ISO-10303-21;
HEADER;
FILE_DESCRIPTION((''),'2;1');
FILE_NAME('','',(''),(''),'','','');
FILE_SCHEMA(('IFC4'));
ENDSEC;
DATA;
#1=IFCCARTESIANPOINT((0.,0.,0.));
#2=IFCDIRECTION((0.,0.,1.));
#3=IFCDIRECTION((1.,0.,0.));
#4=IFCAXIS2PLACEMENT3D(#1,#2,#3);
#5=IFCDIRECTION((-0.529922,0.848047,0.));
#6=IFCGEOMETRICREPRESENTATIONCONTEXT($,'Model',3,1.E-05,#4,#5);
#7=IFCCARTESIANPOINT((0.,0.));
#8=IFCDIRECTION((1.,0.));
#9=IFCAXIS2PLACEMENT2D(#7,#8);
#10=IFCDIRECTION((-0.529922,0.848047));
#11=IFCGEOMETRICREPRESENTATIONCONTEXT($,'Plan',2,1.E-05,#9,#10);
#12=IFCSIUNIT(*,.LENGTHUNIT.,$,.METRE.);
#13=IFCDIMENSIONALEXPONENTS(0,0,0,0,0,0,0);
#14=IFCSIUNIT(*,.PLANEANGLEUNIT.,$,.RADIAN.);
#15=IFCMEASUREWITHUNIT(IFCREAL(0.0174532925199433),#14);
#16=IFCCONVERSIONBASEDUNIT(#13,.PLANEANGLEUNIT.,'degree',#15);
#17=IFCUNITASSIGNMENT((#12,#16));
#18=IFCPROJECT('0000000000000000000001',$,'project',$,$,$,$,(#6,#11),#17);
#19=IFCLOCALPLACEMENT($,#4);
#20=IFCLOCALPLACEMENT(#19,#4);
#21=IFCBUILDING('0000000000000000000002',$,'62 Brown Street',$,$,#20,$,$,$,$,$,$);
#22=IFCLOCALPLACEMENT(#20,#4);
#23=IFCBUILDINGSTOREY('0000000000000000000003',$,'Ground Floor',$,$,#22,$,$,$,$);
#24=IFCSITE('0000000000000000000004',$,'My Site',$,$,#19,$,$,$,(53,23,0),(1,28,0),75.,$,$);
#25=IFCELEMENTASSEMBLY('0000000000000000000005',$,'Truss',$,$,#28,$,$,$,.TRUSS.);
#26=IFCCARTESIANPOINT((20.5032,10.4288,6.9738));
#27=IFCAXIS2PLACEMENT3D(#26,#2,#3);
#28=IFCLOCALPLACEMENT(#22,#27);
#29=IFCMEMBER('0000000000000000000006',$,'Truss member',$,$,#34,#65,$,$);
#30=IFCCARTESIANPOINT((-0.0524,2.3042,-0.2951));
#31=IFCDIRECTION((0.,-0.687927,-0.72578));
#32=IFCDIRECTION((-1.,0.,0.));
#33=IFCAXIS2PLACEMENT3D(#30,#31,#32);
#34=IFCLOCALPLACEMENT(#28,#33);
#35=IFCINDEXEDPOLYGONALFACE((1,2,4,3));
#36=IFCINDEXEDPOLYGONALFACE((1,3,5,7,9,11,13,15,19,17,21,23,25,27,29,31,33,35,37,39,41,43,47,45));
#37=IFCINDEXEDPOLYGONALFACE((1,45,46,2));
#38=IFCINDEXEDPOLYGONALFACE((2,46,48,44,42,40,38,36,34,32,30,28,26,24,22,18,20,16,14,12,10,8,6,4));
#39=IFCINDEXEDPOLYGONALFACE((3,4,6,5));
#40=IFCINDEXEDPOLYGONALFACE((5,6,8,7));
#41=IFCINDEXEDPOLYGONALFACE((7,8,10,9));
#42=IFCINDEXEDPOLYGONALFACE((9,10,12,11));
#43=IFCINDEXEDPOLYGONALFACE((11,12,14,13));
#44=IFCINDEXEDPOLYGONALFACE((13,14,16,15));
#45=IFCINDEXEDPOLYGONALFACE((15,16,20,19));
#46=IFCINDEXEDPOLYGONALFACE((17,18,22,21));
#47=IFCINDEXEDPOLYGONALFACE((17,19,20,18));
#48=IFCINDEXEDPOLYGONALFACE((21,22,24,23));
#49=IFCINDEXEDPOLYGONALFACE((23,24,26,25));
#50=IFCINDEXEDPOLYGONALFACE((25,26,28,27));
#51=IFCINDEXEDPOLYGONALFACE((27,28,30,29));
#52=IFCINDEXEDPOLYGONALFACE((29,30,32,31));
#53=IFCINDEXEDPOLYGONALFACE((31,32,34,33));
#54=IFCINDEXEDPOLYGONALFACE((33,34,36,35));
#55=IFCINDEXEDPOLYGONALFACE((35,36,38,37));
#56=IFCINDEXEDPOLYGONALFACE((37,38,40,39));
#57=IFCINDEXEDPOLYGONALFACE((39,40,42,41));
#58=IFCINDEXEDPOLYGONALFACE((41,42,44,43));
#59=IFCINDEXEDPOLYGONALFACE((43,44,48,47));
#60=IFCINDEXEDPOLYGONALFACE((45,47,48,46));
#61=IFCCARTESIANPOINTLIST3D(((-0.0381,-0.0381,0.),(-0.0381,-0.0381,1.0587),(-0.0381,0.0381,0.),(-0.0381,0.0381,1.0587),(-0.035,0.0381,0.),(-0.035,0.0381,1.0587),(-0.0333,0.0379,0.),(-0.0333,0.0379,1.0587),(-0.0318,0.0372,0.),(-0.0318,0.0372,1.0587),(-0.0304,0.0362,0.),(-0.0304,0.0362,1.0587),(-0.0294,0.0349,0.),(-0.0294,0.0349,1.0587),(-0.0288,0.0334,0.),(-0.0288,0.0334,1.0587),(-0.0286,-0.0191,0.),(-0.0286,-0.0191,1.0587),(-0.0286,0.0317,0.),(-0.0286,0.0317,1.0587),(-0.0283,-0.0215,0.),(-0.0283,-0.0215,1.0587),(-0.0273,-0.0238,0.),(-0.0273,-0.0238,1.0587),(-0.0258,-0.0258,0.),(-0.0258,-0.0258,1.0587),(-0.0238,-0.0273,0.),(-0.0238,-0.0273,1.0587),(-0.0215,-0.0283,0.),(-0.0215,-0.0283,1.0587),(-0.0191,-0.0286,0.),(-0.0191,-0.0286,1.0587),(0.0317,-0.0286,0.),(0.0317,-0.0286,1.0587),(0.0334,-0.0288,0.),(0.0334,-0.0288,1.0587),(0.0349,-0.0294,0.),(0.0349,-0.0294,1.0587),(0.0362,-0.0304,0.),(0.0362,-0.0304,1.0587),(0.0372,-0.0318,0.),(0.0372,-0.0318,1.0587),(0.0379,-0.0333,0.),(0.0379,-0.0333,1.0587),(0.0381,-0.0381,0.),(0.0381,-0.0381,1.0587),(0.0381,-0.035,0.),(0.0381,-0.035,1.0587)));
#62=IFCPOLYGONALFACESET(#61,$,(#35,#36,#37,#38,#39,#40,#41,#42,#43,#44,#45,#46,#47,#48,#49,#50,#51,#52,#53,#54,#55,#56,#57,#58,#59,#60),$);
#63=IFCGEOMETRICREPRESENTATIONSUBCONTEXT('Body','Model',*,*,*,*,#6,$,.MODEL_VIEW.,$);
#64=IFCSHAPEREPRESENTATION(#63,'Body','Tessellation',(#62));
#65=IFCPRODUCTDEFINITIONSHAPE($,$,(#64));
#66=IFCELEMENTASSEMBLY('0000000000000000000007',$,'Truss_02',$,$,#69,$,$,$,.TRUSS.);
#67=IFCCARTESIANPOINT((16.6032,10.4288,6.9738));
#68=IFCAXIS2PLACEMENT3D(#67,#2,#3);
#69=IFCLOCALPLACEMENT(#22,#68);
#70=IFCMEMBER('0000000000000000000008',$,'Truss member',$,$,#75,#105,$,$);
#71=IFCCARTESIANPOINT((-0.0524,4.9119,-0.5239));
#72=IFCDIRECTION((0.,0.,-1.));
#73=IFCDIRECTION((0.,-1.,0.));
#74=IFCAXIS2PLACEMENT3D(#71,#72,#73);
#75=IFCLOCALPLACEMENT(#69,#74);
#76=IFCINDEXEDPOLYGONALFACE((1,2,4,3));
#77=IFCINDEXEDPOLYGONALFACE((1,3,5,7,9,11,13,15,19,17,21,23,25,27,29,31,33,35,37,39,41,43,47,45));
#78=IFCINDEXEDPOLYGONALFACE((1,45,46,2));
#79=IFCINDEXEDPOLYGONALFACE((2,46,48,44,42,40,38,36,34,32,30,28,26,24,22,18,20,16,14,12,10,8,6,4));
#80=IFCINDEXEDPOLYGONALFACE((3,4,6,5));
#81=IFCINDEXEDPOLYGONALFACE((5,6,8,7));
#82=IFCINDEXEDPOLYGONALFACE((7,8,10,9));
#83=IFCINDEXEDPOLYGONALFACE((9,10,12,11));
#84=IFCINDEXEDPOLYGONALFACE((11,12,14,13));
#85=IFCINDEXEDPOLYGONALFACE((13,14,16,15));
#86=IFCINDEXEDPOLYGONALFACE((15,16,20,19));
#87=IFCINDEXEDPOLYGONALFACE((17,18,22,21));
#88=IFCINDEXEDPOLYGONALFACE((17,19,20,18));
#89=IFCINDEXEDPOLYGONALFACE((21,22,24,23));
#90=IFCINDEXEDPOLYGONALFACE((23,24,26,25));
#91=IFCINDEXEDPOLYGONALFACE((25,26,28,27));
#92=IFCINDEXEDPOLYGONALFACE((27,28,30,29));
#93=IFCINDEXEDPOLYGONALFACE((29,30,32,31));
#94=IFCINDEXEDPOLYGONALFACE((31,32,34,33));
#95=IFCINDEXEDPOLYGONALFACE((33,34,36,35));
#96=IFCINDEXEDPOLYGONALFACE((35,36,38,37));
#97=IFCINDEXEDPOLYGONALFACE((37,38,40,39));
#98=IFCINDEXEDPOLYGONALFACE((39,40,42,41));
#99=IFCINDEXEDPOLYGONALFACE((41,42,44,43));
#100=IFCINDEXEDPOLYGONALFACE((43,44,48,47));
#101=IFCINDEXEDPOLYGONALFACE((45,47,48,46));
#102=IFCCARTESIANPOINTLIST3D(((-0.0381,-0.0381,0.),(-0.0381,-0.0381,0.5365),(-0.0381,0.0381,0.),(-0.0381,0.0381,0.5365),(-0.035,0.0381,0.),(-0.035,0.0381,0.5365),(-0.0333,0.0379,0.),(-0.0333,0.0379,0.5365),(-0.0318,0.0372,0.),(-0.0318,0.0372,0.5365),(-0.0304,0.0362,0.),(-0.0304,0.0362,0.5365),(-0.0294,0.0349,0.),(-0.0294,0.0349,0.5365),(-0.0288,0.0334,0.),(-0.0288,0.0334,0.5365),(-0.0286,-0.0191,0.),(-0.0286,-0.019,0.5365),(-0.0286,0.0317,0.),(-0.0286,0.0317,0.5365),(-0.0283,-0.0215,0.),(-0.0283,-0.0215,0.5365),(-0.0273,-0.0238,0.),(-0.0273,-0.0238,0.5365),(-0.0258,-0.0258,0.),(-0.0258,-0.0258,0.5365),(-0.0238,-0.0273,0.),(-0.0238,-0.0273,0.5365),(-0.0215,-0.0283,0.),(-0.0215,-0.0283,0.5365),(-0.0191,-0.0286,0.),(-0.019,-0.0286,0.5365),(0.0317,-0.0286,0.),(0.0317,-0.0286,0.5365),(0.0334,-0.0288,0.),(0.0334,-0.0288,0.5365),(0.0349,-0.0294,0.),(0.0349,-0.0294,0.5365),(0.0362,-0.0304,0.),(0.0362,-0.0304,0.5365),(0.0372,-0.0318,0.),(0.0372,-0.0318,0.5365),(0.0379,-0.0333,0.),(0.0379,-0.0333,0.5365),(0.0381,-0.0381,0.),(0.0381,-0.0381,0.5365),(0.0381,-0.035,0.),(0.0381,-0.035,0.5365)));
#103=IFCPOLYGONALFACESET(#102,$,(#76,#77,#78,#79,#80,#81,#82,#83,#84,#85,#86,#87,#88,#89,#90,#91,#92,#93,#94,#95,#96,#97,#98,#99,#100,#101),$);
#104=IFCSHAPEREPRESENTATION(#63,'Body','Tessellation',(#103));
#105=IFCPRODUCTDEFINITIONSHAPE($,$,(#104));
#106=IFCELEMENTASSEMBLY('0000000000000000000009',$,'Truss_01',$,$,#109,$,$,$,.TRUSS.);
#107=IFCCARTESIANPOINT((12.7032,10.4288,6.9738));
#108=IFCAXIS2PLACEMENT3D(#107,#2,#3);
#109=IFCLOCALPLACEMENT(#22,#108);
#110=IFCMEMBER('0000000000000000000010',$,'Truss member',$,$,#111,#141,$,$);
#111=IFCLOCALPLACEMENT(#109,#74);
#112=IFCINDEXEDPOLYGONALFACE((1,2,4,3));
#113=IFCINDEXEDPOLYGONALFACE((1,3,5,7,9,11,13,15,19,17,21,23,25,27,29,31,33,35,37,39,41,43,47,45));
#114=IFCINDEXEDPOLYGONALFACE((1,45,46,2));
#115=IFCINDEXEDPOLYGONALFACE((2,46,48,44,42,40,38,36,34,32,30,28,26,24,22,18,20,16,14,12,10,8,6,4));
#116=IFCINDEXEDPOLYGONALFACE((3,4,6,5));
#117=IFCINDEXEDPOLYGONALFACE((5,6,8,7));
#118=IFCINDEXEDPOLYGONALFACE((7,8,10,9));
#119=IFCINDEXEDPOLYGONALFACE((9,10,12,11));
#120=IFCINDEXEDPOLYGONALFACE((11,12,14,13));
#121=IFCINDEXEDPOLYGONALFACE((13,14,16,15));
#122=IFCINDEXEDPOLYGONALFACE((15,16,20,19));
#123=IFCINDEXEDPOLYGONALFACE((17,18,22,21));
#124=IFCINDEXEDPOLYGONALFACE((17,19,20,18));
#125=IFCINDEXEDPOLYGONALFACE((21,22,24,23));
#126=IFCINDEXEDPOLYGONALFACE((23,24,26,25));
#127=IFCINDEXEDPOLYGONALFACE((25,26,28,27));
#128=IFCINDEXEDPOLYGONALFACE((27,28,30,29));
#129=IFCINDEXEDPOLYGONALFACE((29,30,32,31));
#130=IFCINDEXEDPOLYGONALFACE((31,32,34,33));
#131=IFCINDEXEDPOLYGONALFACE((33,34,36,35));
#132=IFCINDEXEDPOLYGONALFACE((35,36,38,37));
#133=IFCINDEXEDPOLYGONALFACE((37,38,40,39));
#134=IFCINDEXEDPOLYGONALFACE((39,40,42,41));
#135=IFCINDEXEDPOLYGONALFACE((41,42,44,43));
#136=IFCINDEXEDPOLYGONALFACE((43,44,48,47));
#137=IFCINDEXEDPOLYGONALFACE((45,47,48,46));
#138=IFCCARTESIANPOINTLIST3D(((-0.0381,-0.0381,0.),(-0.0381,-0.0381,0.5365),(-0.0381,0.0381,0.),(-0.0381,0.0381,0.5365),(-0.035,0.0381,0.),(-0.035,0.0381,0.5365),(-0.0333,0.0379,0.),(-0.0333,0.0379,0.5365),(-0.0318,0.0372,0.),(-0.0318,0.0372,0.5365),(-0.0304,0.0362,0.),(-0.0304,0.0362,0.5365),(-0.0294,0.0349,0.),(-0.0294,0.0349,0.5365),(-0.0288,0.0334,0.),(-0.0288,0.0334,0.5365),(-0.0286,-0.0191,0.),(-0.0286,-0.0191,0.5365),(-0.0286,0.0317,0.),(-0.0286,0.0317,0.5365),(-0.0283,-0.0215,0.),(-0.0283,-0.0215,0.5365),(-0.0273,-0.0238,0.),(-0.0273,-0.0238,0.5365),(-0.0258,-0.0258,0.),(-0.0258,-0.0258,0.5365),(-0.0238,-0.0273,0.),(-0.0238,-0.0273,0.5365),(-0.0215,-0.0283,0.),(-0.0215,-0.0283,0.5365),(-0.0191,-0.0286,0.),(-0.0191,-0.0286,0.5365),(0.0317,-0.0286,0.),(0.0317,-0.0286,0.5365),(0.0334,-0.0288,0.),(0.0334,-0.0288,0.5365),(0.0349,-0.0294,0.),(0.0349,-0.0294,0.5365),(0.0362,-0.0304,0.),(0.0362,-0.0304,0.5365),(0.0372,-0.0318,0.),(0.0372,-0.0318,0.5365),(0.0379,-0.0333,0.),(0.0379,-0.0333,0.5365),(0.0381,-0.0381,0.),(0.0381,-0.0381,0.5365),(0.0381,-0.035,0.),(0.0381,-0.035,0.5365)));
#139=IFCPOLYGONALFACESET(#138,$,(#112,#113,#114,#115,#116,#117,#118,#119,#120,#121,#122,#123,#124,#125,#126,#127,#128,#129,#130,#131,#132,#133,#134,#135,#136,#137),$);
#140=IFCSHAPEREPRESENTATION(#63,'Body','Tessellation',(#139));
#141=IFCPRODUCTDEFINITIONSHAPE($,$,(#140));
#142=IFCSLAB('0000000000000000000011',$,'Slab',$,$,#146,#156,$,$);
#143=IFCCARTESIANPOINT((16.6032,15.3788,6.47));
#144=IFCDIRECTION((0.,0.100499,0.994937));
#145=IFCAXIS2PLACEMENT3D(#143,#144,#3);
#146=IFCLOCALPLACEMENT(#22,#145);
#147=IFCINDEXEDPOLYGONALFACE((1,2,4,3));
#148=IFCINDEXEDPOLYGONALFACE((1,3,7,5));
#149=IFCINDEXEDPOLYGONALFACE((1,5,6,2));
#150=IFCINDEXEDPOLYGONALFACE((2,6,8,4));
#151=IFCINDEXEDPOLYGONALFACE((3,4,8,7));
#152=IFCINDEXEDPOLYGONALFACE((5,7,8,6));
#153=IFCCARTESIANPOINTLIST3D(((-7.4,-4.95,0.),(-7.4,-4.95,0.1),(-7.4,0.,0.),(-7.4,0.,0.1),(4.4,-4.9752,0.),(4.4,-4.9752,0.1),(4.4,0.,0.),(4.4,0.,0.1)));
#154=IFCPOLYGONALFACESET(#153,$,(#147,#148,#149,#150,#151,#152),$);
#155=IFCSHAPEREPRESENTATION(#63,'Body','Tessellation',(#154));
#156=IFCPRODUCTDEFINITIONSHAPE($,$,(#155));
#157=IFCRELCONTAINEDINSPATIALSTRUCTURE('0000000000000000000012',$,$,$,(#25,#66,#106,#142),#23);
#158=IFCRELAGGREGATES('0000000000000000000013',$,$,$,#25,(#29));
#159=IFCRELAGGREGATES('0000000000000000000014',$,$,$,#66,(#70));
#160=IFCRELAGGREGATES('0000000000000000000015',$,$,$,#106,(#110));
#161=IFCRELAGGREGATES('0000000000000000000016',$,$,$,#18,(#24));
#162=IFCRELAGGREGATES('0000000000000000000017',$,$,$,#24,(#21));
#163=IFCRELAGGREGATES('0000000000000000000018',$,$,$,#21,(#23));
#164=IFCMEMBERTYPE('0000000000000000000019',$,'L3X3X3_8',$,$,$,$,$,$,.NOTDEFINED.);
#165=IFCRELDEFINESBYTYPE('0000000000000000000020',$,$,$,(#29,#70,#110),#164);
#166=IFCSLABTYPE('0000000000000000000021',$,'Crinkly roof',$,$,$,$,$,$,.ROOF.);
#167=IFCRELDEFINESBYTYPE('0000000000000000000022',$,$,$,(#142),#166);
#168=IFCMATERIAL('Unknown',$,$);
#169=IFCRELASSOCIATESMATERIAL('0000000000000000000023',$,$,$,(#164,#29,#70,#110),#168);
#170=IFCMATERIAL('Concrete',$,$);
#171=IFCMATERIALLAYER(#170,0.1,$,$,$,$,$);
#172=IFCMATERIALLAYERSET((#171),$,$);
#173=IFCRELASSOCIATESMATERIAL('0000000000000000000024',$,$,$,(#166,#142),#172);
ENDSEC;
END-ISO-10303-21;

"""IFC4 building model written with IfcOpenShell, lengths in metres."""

from ifc_helpers import new_model, entity, si_unit, converted_unit, direction, frame, origin_with_axes, origin_2d_with_axis, place, context, subcontext, project, spatial, indexed_curve, l_section, outline, extrude, material, layer, layer_set, layer_usage, material_profile, profile_set, profile_usage, type_object, element, aggregate, save


model = new_model("IFC4")

# Units and contexts
model_context = context("Model", 3, precision=1e-05, world=origin_with_axes(), true_north=direction((-0.529922, 0.848047, 0.0)))
plan_context = context("Plan", 2, precision=1e-05, world=origin_2d_with_axis(), true_north=direction((-0.529922, 0.848047)))
body_context = subcontext(model_context, "Body", "Model", "MODEL_VIEW")
ifc_project = project(units=[si_unit("LENGTHUNIT", "METRE"), converted_unit("PLANEANGLEUNIT", "degree", entity("IfcReal", 0.0174532925199433), si_unit("PLANEANGLEUNIT", "RADIAN"), dimensions=[0, 0, 0, 0, 0, 0, 0])], contexts=[model_context, plan_context])

# Site, building, storey
site_placement = place(None, origin_with_axes())
site = spatial("IfcSite", under=ifc_project, at=site_placement, Name="My Site", RefLatitude=(53, 23, 0), RefLongitude=(1, 28, 0), RefElevation=75.0)
building_placement = place(site_placement, origin_with_axes())
building = spatial("IfcBuilding", under=site, at=building_placement, Name="62 Brown Street")
storey_placement = place(building_placement, origin_with_axes())
storey = spatial("IfcBuildingStorey", under=building, at=storey_placement, Name="Ground Floor")

# Element assemblies, members
assembly_1_placement = place(storey_placement, frame((20.5032, 10.4288, 6.9738), z_axis=(0.0, 0.0, 1.0), x_axis=(1.0, 0.0, 0.0)))
assembly_1 = element("IfcElementAssembly", 1, at=assembly_1_placement, inside=storey, Name="Truss", PredefinedType="TRUSS")
ifc_material_1 = material(Name="Unknown")
ifc_material_profile_1 = material_profile(ifc_material_1, l_section(Depth=0.0762, Width=0.0762, Thickness=0.0095, FilletRadius=0.0095, EdgeRadius=0.0064))
ifc_profile_set_1 = profile_set([ifc_material_profile_1])
member_type_1 = type_object("IfcMemberType", Name="L3X3X3_8", PredefinedType="NOTDEFINED", material=ifc_profile_set_1)
ifc_profile_usage_1 = profile_usage(ifc_profile_set_1, cardinal=5)
member_1_placement = place(assembly_1_placement, frame((-0.0524, 2.3042, -0.2951), z_axis=(0.0, -0.687927, -0.72578), x_axis=(-1.0, 0.0, 0.0)))
member_1 = element("IfcMember", 2, at=member_1_placement, type_object=member_type_1, material=ifc_profile_usage_1, Name="Truss member", context=body_context, shape_type="SweptSolid", body=[
    extrude(l_section(Depth=0.0762, Width=0.0762, Thickness=0.0095, FilletRadius=0.0095, EdgeRadius=0.0064), origin_with_axes(), (0.0, 0.0, 1.0), 1.0587),
])
aggregate(assembly_1, [member_1])
assembly_2_placement = place(storey_placement, frame((16.6032, 10.4288, 6.9738), z_axis=(0.0, 0.0, 1.0), x_axis=(1.0, 0.0, 0.0)))
assembly_2 = element("IfcElementAssembly", 3, at=assembly_2_placement, inside=storey, Name="Truss_02", PredefinedType="TRUSS")
ifc_profile_usage_2 = profile_usage(ifc_profile_set_1, cardinal=5)
member_2_placement = place(assembly_2_placement, frame((-0.0524, 4.9119, -0.5239), z_axis=(0.0, 0.0, -1.0), x_axis=(0.0, -1.0, 0.0)))
member_2 = element("IfcMember", 4, at=member_2_placement, type_object=member_type_1, material=ifc_profile_usage_2, Name="Truss member", context=body_context, shape_type="SweptSolid", body=[
    extrude(l_section(Depth=0.0762, Width=0.0762, Thickness=0.0095, FilletRadius=0.0095, EdgeRadius=0.0064), origin_with_axes(), (0.0, 0.0, 1.0), 0.5365),
])
assembly_3_placement = place(storey_placement, frame((12.7032, 10.4288, 6.9738), z_axis=(0.0, 0.0, 1.0), x_axis=(1.0, 0.0, 0.0)))
assembly_3 = element("IfcElementAssembly", 5, at=assembly_3_placement, inside=storey, Name="Truss_01", PredefinedType="TRUSS")
ifc_profile_usage_3 = profile_usage(ifc_profile_set_1, cardinal=5)
member_3_placement = place(assembly_3_placement, frame((-0.0524, 4.9119, -0.5239), z_axis=(0.0, 0.0, -1.0), x_axis=(0.0, -1.0, 0.0)))
member_3 = element("IfcMember", 6, at=member_3_placement, type_object=member_type_1, material=ifc_profile_usage_3, Name="Truss member", context=body_context, shape_type="SweptSolid", body=[
    extrude(l_section(Depth=0.0762, Width=0.0762, Thickness=0.0095, FilletRadius=0.0095, EdgeRadius=0.0064), origin_with_axes(), (0.0, 0.0, 1.0), 0.5365),
])

aggregate(assembly_2, [member_2])
aggregate(assembly_3, [member_3])

# Slab
ifc_material_2 = material(Name="Concrete")
ifc_layer = layer(ifc_material_2, 0.1)
ifc_layer_set = layer_set([ifc_layer])
ifc_layer_usage = layer_usage(ifc_layer_set, "AXIS3", "POSITIVE", 0.0)
slab_type = type_object("IfcSlabType", Name="Crinkly roof", PredefinedType="ROOF", material=ifc_layer_set)
slab_placement = place(storey_placement, frame((16.6032, 15.3788, 6.47), z_axis=(0.0, 0.100499, 0.994937), x_axis=(1.0, 0.0, 0.0)))
element("IfcSlab", 7, at=slab_placement, inside=storey, type_object=slab_type, material=ifc_layer_usage, Name="Slab", context=body_context, shape_type="SweptSolid", body=[
    extrude(outline(indexed_curve([(4.4, 0.0), (-7.4, 0.0), (-7.4, -4.95), (4.4, -4.9752), (4.4, 0.0)])), None, (0.0, 0.0, 1.0), 0.1),
])

save(model, "model.ifc")
